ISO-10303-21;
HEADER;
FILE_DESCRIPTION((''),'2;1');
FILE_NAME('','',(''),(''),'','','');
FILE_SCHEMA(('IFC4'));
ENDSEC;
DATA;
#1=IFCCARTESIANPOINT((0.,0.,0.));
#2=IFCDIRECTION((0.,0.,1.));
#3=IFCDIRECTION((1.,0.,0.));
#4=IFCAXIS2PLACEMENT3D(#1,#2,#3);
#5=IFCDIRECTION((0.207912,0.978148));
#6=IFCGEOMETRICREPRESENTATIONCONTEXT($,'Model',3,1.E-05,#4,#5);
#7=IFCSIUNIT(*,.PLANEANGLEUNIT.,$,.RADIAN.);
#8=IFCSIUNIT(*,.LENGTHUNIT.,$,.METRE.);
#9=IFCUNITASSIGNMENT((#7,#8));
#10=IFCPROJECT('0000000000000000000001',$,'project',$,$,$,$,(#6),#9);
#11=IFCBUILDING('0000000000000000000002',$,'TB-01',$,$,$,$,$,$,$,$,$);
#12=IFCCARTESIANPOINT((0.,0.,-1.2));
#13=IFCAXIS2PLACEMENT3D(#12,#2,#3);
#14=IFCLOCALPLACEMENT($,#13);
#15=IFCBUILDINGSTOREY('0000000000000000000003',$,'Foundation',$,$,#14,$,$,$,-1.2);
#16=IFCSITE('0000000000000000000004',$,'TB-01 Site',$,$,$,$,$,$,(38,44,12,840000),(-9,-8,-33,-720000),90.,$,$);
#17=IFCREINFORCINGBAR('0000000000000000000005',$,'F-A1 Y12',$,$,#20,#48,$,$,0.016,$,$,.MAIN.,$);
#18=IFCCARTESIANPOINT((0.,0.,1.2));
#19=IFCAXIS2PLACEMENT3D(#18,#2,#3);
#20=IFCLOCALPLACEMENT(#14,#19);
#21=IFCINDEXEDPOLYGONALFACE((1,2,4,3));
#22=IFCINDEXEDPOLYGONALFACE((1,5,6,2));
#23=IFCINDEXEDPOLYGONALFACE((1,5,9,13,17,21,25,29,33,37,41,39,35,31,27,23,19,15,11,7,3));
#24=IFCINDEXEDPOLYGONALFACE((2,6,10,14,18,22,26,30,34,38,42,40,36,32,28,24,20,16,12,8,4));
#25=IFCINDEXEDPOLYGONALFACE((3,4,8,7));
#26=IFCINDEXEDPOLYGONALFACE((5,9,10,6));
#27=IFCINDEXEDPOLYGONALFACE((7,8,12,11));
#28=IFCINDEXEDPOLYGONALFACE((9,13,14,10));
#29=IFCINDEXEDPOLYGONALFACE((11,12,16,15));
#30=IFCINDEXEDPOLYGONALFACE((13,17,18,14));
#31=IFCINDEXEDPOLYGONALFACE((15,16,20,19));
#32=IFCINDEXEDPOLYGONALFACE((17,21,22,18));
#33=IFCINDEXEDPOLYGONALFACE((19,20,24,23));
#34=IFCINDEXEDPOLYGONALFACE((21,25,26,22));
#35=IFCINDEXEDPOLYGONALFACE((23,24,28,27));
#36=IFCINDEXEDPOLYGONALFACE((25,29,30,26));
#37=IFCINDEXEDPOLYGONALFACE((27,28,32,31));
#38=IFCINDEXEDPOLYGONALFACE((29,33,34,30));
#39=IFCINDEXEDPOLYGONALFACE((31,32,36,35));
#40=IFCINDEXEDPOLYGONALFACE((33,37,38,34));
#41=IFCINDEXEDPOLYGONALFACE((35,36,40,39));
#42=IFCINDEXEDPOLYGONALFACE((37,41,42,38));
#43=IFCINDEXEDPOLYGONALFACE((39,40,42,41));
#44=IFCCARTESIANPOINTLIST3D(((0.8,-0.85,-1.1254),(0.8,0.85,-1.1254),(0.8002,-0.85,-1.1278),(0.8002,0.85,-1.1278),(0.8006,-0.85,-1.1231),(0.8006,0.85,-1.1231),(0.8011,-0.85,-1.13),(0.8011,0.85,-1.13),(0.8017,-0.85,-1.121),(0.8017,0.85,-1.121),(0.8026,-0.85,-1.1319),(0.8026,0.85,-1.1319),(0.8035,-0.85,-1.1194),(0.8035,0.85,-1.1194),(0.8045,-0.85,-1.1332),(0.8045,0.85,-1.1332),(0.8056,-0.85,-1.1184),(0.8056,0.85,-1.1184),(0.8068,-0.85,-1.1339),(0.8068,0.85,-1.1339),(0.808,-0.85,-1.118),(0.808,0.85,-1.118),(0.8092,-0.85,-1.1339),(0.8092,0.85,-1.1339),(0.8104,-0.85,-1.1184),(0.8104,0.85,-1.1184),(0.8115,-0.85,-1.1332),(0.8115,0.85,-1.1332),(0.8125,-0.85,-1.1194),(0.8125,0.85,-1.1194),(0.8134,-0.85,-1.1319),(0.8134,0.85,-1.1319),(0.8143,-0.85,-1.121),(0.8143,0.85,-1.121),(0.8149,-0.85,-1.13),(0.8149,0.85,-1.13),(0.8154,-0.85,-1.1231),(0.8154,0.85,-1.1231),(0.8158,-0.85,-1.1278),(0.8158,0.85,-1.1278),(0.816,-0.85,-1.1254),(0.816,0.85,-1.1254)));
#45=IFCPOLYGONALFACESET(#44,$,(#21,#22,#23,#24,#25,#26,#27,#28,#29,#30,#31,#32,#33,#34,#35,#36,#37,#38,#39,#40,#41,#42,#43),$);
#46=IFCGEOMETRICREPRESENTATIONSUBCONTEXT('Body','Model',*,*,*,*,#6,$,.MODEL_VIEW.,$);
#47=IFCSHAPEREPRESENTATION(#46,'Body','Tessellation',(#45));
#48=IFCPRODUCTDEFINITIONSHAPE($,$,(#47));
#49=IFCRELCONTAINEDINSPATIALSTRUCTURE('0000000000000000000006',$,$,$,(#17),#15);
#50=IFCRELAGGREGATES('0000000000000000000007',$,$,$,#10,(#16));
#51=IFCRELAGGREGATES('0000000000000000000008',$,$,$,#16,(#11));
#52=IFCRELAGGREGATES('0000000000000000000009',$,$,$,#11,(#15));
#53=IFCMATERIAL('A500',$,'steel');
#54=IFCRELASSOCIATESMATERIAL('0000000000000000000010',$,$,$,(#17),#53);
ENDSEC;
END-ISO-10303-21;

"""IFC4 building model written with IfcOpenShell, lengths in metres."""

from ifc_helpers import new_model, entity, si_unit, direction, frame, origin_with_axes, place, context, subcontext, project, spatial, material, element, save


model = new_model("IFC4")

# Units and contexts
model_context = context("Model", 3, precision=1e-05, world=origin_with_axes(), true_north=direction((0.207912, 0.978148)))
body_context = subcontext(model_context, "Body", "Model", "MODEL_VIEW")
ifc_project = project(units=[si_unit("PLANEANGLEUNIT", "RADIAN"), si_unit("LENGTHUNIT", "METRE")], contexts=[model_context])

# Site, building, storey
site = spatial("IfcSite", under=ifc_project, Name="TB-01 Site", RefLatitude=(38, 44, 12, 840000), RefLongitude=(-9, -8, -33, -720000), RefElevation=90.0)
building = spatial("IfcBuilding", under=site, Name="TB-01")
storey_placement = place(None, frame((0.0, 0.0, -1.2), z_axis=(0.0, 0.0, 1.0), x_axis=(1.0, 0.0, 0.0)))
storey = spatial("IfcBuildingStorey", under=building, at=storey_placement, Name="Foundation", Elevation=-1.2)

# Reinforcing bar
ifc_material_1 = material(Name="A500", Category="steel")
reinforcing_bar_1_placement = place(storey_placement, frame((0.0, 0.0, 1.2), z_axis=(0.0, 0.0, 1.0), x_axis=(1.0, 0.0, 0.0)))
element("IfcReinforcingBar", 1, at=reinforcing_bar_1_placement, inside=storey, material=ifc_material_1, Name="F-A1 Y12", NominalDiameter=0.016, PredefinedType="MAIN", context=body_context, shape_type="AdvancedSweptSolid", body=[
    entity("IfcSweptDiskSolid", entity("IfcPolyline", [entity("IfcCartesianPoint", [0.808, -0.85, -1.126]), entity("IfcCartesianPoint", [0.808, 0.85, -1.126])]), 0.008),
])

save(model, "model.ifc")
